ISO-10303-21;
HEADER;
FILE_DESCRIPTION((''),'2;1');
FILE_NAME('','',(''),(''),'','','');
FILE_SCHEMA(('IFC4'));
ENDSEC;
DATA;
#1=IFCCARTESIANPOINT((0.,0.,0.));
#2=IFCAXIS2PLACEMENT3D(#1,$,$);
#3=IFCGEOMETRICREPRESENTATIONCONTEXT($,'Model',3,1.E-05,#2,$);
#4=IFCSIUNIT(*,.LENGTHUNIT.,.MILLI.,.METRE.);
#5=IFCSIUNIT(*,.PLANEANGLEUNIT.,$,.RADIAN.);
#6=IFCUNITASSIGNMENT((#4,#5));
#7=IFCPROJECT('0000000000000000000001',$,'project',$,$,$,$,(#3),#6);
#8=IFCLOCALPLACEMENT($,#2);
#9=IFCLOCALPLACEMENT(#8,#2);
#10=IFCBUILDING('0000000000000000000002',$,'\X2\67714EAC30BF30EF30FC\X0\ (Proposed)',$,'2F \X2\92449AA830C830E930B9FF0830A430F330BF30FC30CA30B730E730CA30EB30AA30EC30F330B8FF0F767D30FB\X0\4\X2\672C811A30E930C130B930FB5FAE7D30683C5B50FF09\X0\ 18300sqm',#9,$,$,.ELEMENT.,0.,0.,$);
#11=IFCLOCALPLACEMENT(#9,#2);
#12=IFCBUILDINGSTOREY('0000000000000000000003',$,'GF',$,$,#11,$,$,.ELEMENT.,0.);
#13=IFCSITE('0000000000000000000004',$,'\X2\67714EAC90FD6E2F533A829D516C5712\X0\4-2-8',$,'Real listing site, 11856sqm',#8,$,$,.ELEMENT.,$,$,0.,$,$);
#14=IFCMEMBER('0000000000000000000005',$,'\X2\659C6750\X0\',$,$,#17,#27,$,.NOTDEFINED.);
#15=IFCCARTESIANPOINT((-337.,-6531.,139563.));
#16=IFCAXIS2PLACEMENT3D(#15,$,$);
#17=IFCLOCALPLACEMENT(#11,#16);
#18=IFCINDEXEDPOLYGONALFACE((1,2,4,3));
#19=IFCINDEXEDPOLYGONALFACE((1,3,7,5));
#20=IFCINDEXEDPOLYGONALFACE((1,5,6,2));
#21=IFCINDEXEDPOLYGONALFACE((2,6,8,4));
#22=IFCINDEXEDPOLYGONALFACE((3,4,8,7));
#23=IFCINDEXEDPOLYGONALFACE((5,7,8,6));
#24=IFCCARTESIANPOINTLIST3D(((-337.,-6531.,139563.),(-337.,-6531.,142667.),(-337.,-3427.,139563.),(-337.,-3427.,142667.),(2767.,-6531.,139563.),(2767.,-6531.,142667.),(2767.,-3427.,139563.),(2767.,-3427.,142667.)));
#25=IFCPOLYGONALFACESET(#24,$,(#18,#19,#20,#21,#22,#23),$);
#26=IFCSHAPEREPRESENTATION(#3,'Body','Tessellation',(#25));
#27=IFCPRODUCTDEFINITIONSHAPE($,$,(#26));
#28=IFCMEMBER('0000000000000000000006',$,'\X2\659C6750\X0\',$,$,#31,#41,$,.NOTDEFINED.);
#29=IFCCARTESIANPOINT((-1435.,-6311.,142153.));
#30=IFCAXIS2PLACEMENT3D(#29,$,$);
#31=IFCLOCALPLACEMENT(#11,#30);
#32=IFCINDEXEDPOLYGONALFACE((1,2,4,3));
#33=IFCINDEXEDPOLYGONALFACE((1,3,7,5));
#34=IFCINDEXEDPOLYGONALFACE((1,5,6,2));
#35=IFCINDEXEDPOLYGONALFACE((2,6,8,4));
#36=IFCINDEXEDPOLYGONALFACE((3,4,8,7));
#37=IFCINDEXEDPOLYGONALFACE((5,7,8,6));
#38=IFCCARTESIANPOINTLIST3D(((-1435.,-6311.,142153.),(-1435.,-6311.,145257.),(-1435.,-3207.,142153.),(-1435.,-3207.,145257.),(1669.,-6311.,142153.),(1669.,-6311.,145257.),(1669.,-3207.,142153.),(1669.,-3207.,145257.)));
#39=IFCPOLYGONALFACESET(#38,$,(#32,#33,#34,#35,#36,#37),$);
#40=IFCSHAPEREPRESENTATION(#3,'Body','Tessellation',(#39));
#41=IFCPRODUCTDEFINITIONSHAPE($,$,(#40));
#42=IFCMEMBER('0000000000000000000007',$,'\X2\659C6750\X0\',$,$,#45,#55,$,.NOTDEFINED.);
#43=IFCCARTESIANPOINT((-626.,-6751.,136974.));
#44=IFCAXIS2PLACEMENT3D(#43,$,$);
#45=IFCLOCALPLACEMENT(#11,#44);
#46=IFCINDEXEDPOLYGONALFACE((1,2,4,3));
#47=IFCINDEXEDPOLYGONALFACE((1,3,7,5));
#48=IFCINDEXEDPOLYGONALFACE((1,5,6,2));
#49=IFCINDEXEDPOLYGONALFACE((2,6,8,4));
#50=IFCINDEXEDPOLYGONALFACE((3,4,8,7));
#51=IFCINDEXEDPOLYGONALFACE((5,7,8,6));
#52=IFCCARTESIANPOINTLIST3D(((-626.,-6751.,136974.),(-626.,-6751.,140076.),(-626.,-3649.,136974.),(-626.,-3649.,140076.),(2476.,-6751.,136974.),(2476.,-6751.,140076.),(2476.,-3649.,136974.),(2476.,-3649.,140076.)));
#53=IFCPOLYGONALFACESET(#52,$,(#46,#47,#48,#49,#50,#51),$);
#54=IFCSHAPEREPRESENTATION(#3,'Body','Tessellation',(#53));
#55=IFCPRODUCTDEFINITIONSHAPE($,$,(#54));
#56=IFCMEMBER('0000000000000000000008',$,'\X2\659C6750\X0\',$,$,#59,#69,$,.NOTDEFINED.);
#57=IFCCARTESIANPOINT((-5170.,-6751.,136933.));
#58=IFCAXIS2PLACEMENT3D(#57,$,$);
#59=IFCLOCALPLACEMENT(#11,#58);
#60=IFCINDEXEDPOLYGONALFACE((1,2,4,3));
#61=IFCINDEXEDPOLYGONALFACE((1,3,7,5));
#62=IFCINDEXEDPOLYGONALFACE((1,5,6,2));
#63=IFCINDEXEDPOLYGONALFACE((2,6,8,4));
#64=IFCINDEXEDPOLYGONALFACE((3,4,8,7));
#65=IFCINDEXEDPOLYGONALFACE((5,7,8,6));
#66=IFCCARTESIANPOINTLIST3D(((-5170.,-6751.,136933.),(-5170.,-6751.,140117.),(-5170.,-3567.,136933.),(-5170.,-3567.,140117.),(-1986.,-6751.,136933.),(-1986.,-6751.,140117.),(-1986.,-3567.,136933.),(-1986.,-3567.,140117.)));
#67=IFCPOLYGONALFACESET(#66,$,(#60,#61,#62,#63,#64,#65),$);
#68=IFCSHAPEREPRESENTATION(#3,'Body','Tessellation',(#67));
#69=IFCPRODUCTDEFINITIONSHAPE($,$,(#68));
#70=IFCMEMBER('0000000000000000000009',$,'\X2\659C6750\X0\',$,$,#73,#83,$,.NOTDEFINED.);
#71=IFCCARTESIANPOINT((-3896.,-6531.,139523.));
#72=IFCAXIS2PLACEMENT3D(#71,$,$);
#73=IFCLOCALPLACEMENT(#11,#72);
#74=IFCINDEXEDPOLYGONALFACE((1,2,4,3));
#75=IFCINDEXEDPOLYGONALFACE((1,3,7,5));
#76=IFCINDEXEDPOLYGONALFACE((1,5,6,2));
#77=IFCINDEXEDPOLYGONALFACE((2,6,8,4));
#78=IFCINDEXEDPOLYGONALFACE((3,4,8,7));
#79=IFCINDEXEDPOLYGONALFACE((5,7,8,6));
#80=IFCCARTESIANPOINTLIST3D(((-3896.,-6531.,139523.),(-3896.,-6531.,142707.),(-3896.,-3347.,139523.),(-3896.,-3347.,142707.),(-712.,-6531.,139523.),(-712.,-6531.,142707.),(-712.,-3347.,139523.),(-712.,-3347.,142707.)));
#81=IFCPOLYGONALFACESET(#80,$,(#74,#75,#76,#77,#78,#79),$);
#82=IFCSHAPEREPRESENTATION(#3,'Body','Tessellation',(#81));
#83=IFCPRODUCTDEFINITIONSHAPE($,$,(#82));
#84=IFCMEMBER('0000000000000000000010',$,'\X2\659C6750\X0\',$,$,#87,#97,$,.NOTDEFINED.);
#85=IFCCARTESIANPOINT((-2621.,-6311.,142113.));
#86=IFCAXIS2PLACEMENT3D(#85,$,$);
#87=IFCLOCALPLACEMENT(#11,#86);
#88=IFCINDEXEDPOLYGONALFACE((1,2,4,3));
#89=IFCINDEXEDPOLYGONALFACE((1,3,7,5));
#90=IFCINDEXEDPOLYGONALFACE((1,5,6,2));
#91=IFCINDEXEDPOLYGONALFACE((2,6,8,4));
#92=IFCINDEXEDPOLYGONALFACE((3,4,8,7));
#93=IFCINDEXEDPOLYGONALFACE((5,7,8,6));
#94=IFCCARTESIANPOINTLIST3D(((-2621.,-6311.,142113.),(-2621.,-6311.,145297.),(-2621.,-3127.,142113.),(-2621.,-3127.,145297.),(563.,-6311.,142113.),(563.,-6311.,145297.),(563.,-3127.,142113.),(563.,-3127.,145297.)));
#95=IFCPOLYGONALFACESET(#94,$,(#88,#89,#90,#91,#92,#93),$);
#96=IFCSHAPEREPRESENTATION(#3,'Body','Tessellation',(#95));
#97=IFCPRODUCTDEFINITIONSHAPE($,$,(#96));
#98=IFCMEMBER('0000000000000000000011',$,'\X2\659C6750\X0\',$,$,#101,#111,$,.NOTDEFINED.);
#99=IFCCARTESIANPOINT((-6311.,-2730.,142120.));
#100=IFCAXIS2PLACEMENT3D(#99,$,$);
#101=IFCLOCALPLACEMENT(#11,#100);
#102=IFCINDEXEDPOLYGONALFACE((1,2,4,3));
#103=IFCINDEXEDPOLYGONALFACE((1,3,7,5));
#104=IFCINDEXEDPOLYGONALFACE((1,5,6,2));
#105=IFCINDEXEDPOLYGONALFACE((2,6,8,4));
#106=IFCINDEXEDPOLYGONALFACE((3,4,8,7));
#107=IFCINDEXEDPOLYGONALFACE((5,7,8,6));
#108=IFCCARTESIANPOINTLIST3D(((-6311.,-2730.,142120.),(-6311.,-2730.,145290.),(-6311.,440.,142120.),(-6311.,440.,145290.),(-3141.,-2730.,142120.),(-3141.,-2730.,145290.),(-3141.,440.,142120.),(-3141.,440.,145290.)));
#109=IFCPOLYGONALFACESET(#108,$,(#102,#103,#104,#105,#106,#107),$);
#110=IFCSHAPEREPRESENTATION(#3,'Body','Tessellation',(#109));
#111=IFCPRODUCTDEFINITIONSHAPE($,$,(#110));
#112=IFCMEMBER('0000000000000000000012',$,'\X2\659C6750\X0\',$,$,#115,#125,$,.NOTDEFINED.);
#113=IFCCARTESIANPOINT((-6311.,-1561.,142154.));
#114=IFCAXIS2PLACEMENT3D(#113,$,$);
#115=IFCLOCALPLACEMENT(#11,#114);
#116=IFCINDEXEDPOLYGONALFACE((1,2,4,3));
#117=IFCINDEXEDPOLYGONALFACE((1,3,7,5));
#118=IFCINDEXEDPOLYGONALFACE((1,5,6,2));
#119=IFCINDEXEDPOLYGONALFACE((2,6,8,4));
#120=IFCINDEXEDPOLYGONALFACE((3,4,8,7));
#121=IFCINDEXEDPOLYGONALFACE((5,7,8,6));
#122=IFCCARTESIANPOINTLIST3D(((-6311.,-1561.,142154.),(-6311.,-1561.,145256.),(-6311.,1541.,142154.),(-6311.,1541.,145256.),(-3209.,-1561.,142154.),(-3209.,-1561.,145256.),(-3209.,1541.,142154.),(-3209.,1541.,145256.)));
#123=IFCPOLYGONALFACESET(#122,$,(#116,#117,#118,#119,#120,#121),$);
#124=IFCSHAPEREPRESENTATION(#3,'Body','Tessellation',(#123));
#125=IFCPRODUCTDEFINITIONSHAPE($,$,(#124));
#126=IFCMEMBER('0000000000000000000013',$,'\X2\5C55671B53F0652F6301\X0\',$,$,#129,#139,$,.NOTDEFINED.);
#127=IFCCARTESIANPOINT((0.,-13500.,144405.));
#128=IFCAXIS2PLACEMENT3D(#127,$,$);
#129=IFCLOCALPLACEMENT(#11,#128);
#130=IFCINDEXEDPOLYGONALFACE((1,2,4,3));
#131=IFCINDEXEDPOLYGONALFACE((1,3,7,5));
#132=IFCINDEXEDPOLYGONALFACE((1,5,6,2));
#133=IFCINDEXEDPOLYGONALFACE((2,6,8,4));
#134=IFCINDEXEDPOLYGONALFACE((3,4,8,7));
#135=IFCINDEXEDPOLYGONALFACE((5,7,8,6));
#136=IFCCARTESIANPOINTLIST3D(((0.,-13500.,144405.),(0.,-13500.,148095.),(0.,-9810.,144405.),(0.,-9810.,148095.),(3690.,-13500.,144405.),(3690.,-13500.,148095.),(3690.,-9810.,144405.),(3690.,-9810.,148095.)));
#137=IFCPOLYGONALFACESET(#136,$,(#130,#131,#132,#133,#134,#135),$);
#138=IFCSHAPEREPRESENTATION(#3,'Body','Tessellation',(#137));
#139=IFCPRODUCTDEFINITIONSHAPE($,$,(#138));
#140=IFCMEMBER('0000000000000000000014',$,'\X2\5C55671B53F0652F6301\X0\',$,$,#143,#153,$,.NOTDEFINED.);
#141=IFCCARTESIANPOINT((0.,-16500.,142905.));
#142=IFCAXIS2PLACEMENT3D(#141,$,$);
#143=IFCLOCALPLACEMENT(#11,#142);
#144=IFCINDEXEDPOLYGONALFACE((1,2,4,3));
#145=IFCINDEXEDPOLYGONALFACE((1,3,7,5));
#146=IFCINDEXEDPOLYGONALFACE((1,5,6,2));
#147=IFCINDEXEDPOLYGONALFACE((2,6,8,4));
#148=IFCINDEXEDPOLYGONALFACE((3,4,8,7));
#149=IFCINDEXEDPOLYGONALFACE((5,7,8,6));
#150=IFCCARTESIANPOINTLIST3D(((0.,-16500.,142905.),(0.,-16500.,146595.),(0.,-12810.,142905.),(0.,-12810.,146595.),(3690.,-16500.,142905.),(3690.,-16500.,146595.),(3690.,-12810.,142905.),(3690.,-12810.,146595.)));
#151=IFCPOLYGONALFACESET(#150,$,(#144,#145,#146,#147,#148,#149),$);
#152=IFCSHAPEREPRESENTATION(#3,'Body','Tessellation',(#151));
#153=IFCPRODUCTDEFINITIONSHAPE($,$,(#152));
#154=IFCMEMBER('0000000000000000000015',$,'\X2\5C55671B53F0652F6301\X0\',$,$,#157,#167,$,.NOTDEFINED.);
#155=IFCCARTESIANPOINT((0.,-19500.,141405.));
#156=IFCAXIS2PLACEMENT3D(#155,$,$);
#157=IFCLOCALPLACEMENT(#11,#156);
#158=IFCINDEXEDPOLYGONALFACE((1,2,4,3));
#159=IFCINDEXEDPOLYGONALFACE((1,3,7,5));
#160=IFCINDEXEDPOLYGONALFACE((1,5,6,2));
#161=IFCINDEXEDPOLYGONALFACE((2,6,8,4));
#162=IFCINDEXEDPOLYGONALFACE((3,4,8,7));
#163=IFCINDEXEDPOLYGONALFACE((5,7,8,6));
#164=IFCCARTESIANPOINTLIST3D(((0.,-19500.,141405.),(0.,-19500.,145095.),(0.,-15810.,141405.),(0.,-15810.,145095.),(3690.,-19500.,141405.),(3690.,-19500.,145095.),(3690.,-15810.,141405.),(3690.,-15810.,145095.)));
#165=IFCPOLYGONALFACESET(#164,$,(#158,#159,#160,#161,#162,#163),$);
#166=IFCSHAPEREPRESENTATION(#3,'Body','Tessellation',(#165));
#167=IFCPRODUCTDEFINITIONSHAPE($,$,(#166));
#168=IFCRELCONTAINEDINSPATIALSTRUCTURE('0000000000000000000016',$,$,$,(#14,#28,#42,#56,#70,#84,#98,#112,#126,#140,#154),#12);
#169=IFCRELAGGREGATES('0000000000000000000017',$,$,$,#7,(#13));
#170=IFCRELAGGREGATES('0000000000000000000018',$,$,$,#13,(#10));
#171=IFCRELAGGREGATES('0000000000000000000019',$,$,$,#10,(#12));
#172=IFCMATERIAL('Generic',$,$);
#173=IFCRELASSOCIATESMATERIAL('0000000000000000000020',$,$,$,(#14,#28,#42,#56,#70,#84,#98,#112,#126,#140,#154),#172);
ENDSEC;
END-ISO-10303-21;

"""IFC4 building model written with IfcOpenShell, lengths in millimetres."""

from ifc_helpers import new_model, si_unit, frame, frame_2d, origin, place, context, project, spatial, rectangle, extrude, material, element, save


model = new_model("IFC4")

# Units and contexts
model_context = context("Model", 3, precision=1e-05, world=origin())
ifc_project = project(units=[si_unit("LENGTHUNIT", "METRE", prefix="MILLI"), si_unit("PLANEANGLEUNIT", "RADIAN")], contexts=[model_context])

# Site, building, storey
site_placement = place(None, origin())
site = spatial("IfcSite", under=ifc_project, at=site_placement, Name="東京都港区芝公園4-2-8", ObjectType="Real listing site, 11856sqm", CompositionType="ELEMENT", RefElevation=0.0)
building_placement = place(site_placement, origin())
building = spatial("IfcBuilding", under=site, at=building_placement, Name="東京タワー (Proposed)", ObjectType="2F 鉄骨トラス（インターナショナルオレンジ／白・4本脚ラチス・微細格子） 18300sqm", CompositionType="ELEMENT", ElevationOfRefHeight=0.0, ElevationOfTerrain=0.0)
storey_placement = place(building_placement, origin())
storey = spatial("IfcBuildingStorey", under=building, at=storey_placement, Name="GF", CompositionType="ELEMENT", Elevation=0.0)

# Shared definitions
ifc_material = material(Name="Generic")

# Members
member_1_placement = place(storey_placement, frame((-337.0, -6531.0, 139563.0)))
element("IfcMember", 1, at=member_1_placement, inside=storey, material=ifc_material, Name="斜材", PredefinedType="NOTDEFINED", context=model_context, shape_type="SweptSolid", body=[
    extrude(rectangle(XDim=3104.0, YDim=3104.0, at=frame_2d((1552.0, 1552.0))), frame((-337.0, -6531.0, 139563.0)), (0.0, 0.0, 1.0), 3104.0),
])
member_2_placement = place(storey_placement, frame((-1435.0, -6311.0, 142153.0)))
element("IfcMember", 2, at=member_2_placement, inside=storey, material=ifc_material, Name="斜材", PredefinedType="NOTDEFINED", context=model_context, shape_type="SweptSolid", body=[
    extrude(rectangle(XDim=3104.0, YDim=3104.0, at=frame_2d((1552.0, 1552.0))), frame((-1435.0, -6311.0, 142153.0)), (0.0, 0.0, 1.0), 3104.0),
])
member_3_placement = place(storey_placement, frame((-626.0, -6751.0, 136974.0)))
element("IfcMember", 3, at=member_3_placement, inside=storey, material=ifc_material, Name="斜材", PredefinedType="NOTDEFINED", context=model_context, shape_type="SweptSolid", body=[
    extrude(rectangle(XDim=3102.0, YDim=3102.0, at=frame_2d((1551.0, 1551.0))), frame((-626.0, -6751.0, 136974.0)), (0.0, 0.0, 1.0), 3102.0),
])
member_4_placement = place(storey_placement, frame((-5170.0, -6751.0, 136933.0)))
element("IfcMember", 4, at=member_4_placement, inside=storey, material=ifc_material, Name="斜材", PredefinedType="NOTDEFINED", context=model_context, shape_type="SweptSolid", body=[
    extrude(rectangle(XDim=3184.0, YDim=3184.0, at=frame_2d((1592.0, 1592.0))), frame((-5170.0, -6751.0, 136933.0)), (0.0, 0.0, 1.0), 3184.0),
])
member_5_placement = place(storey_placement, frame((-3896.0, -6531.0, 139523.0)))
element("IfcMember", 5, at=member_5_placement, inside=storey, material=ifc_material, Name="斜材", PredefinedType="NOTDEFINED", context=model_context, shape_type="SweptSolid", body=[
    extrude(rectangle(XDim=3184.0, YDim=3184.0, at=frame_2d((1592.0, 1592.0))), frame((-3896.0, -6531.0, 139523.0)), (0.0, 0.0, 1.0), 3184.0),
])
member_6_placement = place(storey_placement, frame((-2621.0, -6311.0, 142113.0)))
element("IfcMember", 6, at=member_6_placement, inside=storey, material=ifc_material, Name="斜材", PredefinedType="NOTDEFINED", context=model_context, shape_type="SweptSolid", body=[
    extrude(rectangle(XDim=3184.0, YDim=3184.0, at=frame_2d((1592.0, 1592.0))), frame((-2621.0, -6311.0, 142113.0)), (0.0, 0.0, 1.0), 3184.0),
])
member_7_placement = place(storey_placement, frame((-6311.0, -2730.0, 142120.0)))
element("IfcMember", 7, at=member_7_placement, inside=storey, material=ifc_material, Name="斜材", PredefinedType="NOTDEFINED", context=model_context, shape_type="SweptSolid", body=[
    extrude(rectangle(XDim=3170.0, YDim=3170.0, at=frame_2d((1585.0, 1585.0))), frame((-6311.0, -2730.0, 142120.0)), (0.0, 0.0, 1.0), 3170.0),
])
member_8_placement = place(storey_placement, frame((-6311.0, -1561.0, 142154.0)))
element("IfcMember", 8, at=member_8_placement, inside=storey, material=ifc_material, Name="斜材", PredefinedType="NOTDEFINED", context=model_context, shape_type="SweptSolid", body=[
    extrude(rectangle(XDim=3102.0, YDim=3102.0, at=frame_2d((1551.0, 1551.0))), frame((-6311.0, -1561.0, 142154.0)), (0.0, 0.0, 1.0), 3102.0),
])
member_9_placement = place(storey_placement, frame((0.0, -13500.0, 144405.0)))
element("IfcMember", 9, at=member_9_placement, inside=storey, material=ifc_material, Name="展望台支持", PredefinedType="NOTDEFINED", context=model_context, shape_type="SweptSolid", body=[
    extrude(rectangle(XDim=3690.0, YDim=3690.0, at=frame_2d((1845.0, 1845.0))), frame((0.0, -13500.0, 144405.0)), (0.0, 0.0, 1.0), 3690.0),
])
member_10_placement = place(storey_placement, frame((0.0, -16500.0, 142905.0)))
element("IfcMember", 10, at=member_10_placement, inside=storey, material=ifc_material, Name="展望台支持", PredefinedType="NOTDEFINED", context=model_context, shape_type="SweptSolid", body=[
    extrude(rectangle(XDim=3690.0, YDim=3690.0, at=frame_2d((1845.0, 1845.0))), frame((0.0, -16500.0, 142905.0)), (0.0, 0.0, 1.0), 3690.0),
])
member_11_placement = place(storey_placement, frame((0.0, -19500.0, 141405.0)))
element("IfcMember", 11, at=member_11_placement, inside=storey, material=ifc_material, Name="展望台支持", PredefinedType="NOTDEFINED", context=model_context, shape_type="SweptSolid", body=[
    extrude(rectangle(XDim=3690.0, YDim=3690.0, at=frame_2d((1845.0, 1845.0))), frame((0.0, -19500.0, 141405.0)), (0.0, 0.0, 1.0), 3690.0),
])

save(model, "model.ifc")
